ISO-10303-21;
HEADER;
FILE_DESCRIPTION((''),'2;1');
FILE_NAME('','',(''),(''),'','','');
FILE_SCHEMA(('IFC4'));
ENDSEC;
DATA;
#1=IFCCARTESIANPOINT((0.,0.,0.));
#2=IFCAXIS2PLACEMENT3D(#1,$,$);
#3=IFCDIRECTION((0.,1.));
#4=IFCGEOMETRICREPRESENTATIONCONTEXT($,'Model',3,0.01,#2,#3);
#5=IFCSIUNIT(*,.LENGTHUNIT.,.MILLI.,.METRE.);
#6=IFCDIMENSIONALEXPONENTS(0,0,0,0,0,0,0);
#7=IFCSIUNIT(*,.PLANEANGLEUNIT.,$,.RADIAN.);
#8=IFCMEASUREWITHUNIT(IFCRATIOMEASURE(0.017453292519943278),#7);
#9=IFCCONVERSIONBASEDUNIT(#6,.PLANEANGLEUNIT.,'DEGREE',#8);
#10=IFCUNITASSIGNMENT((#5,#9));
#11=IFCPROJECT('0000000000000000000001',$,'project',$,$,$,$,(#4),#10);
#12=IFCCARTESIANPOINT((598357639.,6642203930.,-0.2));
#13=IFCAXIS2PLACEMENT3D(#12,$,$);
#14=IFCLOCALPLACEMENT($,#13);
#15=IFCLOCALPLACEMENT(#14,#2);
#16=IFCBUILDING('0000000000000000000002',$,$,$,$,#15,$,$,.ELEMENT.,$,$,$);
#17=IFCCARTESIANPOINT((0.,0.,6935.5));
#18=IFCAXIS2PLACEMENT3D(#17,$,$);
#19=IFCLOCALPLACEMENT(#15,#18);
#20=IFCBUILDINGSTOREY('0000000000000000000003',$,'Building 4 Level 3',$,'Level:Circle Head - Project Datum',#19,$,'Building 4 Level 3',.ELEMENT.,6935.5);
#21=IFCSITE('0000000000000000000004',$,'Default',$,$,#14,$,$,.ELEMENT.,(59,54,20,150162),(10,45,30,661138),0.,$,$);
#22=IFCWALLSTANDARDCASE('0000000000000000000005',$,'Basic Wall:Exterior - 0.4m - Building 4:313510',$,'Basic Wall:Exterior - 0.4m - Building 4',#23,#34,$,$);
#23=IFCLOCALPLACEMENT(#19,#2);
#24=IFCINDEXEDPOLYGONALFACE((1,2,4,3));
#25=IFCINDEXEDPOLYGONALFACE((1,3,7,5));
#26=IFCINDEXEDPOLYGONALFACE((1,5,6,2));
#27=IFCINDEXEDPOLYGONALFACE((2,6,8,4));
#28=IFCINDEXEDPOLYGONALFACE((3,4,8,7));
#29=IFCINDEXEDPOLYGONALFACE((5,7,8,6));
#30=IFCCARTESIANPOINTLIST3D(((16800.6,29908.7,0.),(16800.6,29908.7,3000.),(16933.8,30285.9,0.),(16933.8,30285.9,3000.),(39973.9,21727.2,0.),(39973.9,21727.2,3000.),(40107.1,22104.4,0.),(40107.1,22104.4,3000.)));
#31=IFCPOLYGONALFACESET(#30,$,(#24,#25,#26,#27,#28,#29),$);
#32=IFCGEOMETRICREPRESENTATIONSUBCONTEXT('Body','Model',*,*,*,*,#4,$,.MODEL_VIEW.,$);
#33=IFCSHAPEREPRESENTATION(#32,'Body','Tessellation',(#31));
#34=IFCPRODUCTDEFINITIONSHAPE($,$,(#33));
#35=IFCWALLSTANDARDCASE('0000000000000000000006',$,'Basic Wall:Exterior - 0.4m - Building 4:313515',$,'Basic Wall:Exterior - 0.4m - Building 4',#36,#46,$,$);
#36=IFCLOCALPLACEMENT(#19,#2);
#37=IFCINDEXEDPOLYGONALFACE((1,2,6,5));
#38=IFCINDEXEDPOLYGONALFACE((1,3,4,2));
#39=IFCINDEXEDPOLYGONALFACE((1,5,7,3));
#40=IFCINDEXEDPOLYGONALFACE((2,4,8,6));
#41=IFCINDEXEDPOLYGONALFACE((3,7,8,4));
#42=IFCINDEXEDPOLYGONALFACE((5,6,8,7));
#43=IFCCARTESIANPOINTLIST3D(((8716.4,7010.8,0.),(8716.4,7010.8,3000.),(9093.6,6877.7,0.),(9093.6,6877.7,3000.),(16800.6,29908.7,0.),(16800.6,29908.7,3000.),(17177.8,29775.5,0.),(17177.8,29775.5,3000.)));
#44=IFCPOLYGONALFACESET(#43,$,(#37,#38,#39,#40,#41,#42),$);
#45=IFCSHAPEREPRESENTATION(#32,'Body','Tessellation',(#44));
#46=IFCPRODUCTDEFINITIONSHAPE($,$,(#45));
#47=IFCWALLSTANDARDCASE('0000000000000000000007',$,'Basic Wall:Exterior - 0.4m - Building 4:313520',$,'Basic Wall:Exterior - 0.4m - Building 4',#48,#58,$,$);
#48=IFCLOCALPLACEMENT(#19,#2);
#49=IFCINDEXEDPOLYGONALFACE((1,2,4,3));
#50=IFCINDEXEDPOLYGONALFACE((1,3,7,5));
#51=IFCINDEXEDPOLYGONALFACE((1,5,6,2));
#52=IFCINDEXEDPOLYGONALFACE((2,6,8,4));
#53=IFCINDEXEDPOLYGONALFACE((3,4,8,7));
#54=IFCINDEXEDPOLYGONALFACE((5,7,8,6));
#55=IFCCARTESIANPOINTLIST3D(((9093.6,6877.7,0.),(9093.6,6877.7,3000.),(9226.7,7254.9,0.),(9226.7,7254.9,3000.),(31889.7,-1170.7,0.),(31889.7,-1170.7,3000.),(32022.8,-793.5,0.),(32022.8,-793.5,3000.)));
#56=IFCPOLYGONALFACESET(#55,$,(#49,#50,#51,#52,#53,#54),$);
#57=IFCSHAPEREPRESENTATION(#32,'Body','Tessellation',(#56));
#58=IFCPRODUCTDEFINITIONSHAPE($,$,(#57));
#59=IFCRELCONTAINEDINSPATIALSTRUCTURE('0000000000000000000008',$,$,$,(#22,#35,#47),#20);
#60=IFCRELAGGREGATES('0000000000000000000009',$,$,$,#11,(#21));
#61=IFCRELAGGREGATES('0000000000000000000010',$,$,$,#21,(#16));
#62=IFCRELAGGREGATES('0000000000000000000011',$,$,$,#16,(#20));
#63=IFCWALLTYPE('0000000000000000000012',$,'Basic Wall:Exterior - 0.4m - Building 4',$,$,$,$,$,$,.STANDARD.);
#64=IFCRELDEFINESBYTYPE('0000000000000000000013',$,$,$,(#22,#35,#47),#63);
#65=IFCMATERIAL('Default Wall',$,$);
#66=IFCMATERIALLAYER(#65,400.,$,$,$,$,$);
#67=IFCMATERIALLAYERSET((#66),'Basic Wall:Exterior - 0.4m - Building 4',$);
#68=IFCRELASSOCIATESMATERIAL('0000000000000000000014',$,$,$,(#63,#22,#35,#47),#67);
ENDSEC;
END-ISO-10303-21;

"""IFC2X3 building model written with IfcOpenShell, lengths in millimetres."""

from ifc_helpers import new_model, entity, si_unit, converted_unit, direction, frame, frame_2d, origin, place, context, subcontext, project, spatial, rectangle, extrude, material, layer, layer_set, layer_usage, type_object, element, save


model = new_model("IFC2X3")

# Units and contexts
model_context = context("Model", 3, precision=0.01, world=origin(), true_north=direction((0.0, 1.0)))
body_context = subcontext(model_context, "Body", "Model", "MODEL_VIEW")
ifc_project = project(units=[si_unit("LENGTHUNIT", "METRE", prefix="MILLI"), converted_unit("PLANEANGLEUNIT", "DEGREE", entity("IfcRatioMeasure", 0.017453292519943278), si_unit("PLANEANGLEUNIT", "RADIAN"), dimensions=[0, 0, 0, 0, 0, 0, 0])], contexts=[model_context])

# Site, building, storey
site_placement = place(None, frame((598357639.0, 6642203930.0, -0.2)))
site = spatial("IfcSite", under=ifc_project, at=site_placement, Name="Default", CompositionType="ELEMENT", RefLatitude=(59, 54, 20, 150162), RefLongitude=(10, 45, 30, 661138), RefElevation=0.0)
building_placement = place(site_placement, origin())
building = spatial("IfcBuilding", under=site, at=building_placement, CompositionType="ELEMENT")
storey_placement = place(building_placement, frame((0.0, 0.0, 6935.5)))
storey = spatial("IfcBuildingStorey", under=building, at=storey_placement, Name="Building 4 Level 3", ObjectType="Level:Circle Head - Project Datum", LongName="Building 4 Level 3", CompositionType="ELEMENT", Elevation=6935.5)

# Walls
ifc_material_1 = material(Name="Default Wall")
ifc_layer_1 = layer(ifc_material_1, 400.0)
ifc_layer_set_1 = layer_set([ifc_layer_1], Name="Basic Wall:Exterior - 0.4m - Building 4")
ifc_layer_usage_1 = layer_usage(ifc_layer_set_1, "AXIS2", "POSITIVE", -200.0)
wall_type = type_object("IfcWallType", Name="Basic Wall:Exterior - 0.4m - Building 4", PredefinedType="STANDARD", material=ifc_layer_set_1)
wall_1_placement = place(storey_placement, frame((40040.5, 21915.8, 0.0), z_axis=(0.0, 0.0, 1.0), x_axis=(-0.942956, 0.332918, 0.0)))
element("IfcWallStandardCase", 1, at=wall_1_placement, inside=storey, type_object=wall_type, material=ifc_layer_usage_1, Name="Basic Wall:Exterior - 0.4m - Building 4:313510", ObjectType="Basic Wall:Exterior - 0.4m - Building 4", context=body_context, shape_type="SweptSolid", body=[
    extrude(rectangle(XDim=24575.2, YDim=400.0, at=frame_2d((12287.6, 0.0), x_axis=(-1.0, 0.0))), origin(), (0.0, 0.0, 1.0), 3000.0),
])
wall_2_placement = place(storey_placement, frame((16989.2, 29842.1, 0.0), z_axis=(0.0, 0.0, 1.0), x_axis=(-0.332918, -0.942956, 0.0)))
element("IfcWallStandardCase", 2, at=wall_2_placement, inside=storey, type_object=wall_type, material=ifc_layer_usage_1, Name="Basic Wall:Exterior - 0.4m - Building 4:313515", ObjectType="Basic Wall:Exterior - 0.4m - Building 4", context=body_context, shape_type="SweptSolid", body=[
    extrude(rectangle(XDim=24283.1, YDim=400.0, at=frame_2d((12141.5, 0.0), x_axis=(-1.0, 0.0))), origin(), (0.0, 0.0, 1.0), 3000.0),
])
wall_3_placement = place(storey_placement, frame((9160.1, 7066.3, 0.0), z_axis=(0.0, 0.0, 1.0), x_axis=(0.942956, -0.332918, 0.0)))
element("IfcWallStandardCase", 3, at=wall_3_placement, inside=storey, type_object=wall_type, material=ifc_layer_usage_1, Name="Basic Wall:Exterior - 0.4m - Building 4:313520", ObjectType="Basic Wall:Exterior - 0.4m - Building 4", context=body_context, shape_type="SweptSolid", body=[
    extrude(rectangle(XDim=24175.2, YDim=400.0, at=frame_2d((12087.6, 0.0), x_axis=(-1.0, 0.0))), origin(), (0.0, 0.0, 1.0), 3000.0),
])

save(model, "model.ifc")
